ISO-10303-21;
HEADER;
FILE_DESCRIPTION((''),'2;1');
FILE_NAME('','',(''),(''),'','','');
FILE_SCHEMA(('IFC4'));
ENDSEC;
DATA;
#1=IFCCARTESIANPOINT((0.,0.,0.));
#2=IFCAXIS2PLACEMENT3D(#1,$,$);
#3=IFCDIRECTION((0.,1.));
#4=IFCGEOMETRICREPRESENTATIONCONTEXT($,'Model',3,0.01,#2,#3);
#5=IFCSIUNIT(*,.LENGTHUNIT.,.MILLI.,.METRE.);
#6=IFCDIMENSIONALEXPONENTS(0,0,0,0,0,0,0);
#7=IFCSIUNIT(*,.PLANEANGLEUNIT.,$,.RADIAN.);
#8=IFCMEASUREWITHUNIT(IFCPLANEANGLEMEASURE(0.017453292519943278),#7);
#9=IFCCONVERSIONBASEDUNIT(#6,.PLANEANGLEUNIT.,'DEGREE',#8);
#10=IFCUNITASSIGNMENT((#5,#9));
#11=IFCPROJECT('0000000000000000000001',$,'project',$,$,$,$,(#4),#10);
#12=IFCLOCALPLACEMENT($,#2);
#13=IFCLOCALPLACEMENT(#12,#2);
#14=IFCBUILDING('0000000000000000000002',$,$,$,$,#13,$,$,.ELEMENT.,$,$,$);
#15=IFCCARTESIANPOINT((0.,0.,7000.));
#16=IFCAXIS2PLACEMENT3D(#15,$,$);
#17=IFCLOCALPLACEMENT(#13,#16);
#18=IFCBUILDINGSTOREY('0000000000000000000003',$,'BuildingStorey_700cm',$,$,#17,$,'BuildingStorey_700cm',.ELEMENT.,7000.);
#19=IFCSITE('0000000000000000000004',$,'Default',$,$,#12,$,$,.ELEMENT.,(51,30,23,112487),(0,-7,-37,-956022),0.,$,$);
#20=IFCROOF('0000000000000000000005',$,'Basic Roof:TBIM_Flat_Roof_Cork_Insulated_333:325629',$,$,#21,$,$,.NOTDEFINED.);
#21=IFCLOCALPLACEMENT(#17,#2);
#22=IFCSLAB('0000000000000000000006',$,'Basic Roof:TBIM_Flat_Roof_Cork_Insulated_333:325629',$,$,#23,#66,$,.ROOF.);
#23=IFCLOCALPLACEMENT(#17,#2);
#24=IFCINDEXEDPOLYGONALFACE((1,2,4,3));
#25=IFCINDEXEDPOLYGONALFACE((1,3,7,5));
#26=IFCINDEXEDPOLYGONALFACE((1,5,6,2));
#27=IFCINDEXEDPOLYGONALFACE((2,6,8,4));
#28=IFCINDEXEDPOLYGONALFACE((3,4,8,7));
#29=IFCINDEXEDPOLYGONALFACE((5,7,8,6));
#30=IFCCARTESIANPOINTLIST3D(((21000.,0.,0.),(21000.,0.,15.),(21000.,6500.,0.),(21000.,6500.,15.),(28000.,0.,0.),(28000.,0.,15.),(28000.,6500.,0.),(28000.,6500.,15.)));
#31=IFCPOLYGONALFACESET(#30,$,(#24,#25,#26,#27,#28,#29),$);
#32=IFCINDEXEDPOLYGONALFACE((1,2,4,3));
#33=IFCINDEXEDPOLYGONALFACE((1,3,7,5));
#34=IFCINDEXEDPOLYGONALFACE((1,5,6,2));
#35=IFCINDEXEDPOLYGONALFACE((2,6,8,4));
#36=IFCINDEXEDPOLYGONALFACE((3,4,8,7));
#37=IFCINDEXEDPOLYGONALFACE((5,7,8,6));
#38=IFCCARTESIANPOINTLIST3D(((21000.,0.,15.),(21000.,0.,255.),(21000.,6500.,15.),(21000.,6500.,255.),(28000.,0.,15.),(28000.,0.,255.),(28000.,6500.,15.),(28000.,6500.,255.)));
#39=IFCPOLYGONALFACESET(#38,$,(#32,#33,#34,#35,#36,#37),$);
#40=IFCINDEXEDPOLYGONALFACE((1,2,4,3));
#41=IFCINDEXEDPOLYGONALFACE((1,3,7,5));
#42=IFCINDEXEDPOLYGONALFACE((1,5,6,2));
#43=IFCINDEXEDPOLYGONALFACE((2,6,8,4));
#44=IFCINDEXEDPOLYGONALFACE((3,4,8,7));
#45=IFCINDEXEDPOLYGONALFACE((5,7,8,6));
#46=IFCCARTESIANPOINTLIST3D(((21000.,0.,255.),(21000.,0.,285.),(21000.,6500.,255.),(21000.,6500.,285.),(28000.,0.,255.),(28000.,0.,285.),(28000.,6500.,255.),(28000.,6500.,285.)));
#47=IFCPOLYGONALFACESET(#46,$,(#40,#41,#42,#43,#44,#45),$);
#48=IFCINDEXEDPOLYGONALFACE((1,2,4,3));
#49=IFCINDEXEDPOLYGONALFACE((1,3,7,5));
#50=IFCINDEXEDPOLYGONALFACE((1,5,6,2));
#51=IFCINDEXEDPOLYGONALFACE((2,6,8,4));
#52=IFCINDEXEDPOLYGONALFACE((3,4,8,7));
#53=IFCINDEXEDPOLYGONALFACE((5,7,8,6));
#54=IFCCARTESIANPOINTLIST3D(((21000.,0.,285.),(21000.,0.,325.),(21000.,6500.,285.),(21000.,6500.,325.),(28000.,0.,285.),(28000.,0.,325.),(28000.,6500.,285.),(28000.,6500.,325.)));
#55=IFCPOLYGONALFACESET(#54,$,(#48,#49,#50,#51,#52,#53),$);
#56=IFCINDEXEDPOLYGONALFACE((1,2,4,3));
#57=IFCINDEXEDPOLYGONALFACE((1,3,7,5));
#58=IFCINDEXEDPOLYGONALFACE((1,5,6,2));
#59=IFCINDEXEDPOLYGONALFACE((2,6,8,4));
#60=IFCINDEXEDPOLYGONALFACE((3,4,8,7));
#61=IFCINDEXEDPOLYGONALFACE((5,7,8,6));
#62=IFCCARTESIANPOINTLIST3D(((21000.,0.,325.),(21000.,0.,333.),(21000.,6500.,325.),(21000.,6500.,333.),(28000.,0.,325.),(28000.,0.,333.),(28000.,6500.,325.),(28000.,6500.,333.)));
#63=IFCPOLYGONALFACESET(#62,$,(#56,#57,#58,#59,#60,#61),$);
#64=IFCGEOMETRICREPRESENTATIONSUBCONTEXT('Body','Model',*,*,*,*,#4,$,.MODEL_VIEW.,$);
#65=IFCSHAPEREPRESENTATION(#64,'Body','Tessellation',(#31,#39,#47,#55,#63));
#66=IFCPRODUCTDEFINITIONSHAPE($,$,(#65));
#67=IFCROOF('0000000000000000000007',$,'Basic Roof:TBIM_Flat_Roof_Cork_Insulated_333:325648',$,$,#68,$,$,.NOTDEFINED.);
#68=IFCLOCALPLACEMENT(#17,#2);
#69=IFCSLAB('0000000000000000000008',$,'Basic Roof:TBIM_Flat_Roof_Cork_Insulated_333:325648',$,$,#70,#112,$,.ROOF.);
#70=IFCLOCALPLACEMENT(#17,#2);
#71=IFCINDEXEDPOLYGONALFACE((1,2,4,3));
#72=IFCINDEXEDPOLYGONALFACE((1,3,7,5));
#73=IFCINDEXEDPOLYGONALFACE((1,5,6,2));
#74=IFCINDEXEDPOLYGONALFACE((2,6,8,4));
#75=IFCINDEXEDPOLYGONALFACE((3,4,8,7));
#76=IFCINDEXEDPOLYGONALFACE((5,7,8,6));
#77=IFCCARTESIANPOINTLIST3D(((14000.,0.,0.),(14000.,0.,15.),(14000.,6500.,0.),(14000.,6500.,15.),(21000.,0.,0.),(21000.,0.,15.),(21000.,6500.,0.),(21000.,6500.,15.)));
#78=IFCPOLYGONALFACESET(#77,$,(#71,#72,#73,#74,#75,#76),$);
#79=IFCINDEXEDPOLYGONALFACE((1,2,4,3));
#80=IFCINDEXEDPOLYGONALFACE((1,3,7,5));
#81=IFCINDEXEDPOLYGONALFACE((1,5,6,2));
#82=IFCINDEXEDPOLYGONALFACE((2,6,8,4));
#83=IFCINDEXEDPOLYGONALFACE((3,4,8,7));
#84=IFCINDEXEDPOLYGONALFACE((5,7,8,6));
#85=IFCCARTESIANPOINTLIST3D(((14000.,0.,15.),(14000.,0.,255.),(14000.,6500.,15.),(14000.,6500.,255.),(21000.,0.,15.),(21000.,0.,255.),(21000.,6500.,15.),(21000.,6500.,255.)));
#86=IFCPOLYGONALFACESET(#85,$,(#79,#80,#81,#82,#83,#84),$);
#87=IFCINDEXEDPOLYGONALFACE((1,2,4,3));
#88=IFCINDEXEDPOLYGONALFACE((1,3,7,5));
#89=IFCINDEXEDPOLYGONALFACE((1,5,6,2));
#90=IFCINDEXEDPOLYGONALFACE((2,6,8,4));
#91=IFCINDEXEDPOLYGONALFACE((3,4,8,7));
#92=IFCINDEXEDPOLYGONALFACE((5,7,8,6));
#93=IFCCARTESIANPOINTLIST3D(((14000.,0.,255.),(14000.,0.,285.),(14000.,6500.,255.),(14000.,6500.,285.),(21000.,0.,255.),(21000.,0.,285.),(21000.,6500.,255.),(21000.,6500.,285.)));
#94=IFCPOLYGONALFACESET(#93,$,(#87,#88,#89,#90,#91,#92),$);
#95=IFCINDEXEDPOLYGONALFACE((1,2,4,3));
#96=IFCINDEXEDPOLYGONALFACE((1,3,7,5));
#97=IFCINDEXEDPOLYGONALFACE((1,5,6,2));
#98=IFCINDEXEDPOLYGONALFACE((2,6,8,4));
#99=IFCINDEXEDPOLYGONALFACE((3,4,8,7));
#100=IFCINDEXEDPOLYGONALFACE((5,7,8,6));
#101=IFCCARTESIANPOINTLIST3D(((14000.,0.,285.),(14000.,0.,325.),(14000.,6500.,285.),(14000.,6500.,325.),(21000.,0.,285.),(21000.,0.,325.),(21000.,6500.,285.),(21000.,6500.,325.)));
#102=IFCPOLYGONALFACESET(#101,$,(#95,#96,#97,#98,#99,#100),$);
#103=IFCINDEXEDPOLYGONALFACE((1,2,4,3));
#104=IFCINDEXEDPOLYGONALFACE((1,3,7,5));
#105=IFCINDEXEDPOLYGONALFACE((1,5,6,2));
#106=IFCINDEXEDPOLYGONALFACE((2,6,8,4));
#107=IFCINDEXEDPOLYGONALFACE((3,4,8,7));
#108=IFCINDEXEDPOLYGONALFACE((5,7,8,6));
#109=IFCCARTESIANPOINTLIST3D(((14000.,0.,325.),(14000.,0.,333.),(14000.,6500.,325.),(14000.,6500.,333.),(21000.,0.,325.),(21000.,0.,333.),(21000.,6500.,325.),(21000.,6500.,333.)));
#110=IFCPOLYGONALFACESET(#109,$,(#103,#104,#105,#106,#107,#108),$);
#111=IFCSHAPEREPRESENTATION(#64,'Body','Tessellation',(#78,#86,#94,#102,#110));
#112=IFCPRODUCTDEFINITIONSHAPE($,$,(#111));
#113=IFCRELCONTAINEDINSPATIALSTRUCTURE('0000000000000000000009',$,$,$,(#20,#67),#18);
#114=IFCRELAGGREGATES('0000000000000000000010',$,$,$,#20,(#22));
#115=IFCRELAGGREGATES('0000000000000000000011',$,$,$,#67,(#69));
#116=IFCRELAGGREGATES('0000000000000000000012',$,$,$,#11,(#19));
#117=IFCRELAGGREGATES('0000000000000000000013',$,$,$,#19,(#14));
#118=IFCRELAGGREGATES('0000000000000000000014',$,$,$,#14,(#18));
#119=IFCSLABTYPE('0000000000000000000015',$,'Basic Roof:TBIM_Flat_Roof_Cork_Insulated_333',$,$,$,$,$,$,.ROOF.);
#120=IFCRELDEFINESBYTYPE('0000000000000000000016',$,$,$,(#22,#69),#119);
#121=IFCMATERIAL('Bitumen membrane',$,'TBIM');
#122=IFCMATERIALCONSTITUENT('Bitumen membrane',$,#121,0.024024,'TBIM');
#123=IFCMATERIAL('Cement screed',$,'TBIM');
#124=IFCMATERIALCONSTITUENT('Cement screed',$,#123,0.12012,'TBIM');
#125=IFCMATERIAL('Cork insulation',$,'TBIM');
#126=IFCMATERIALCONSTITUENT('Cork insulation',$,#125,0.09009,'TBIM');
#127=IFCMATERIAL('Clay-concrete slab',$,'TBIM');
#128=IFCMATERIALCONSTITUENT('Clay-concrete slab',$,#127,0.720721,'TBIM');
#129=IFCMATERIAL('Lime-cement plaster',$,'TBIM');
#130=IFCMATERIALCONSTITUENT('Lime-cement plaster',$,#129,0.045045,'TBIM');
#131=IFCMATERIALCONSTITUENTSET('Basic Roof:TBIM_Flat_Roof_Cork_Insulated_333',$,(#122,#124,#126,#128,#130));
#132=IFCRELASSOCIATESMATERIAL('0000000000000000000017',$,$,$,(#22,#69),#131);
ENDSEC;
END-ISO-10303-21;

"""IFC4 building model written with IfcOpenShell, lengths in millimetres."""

from ifc_helpers import new_model, entity, si_unit, converted_unit, direction, frame, origin, place, context, subcontext, project, spatial, indexed_curve, outline, extrude, material, constituent, constituent_set, type_object, element, aggregate, save


model = new_model("IFC4")

# Units and contexts
model_context = context("Model", 3, precision=0.01, world=origin(), true_north=direction((0.0, 1.0)))
body_context = subcontext(model_context, "Body", "Model", "MODEL_VIEW")
ifc_project = project(units=[si_unit("LENGTHUNIT", "METRE", prefix="MILLI"), converted_unit("PLANEANGLEUNIT", "DEGREE", entity("IfcPlaneAngleMeasure", 0.017453292519943278), si_unit("PLANEANGLEUNIT", "RADIAN"), dimensions=[0, 0, 0, 0, 0, 0, 0])], contexts=[model_context])

# Site, building, storey
site_placement = place(None, origin())
site = spatial("IfcSite", under=ifc_project, at=site_placement, Name="Default", CompositionType="ELEMENT", RefLatitude=(51, 30, 23, 112487), RefLongitude=(0, -7, -37, -956022), RefElevation=0.0)
building_placement = place(site_placement, origin())
building = spatial("IfcBuilding", under=site, at=building_placement, CompositionType="ELEMENT")
storey_placement = place(building_placement, frame((0.0, 0.0, 7000.0)))
storey = spatial("IfcBuildingStorey", under=building, at=storey_placement, Name="BuildingStorey_700cm", LongName="BuildingStorey_700cm", CompositionType="ELEMENT", Elevation=7000.0)

# Roofs, slabs
ifc_material_1 = material(Name="Bitumen membrane", Category="TBIM")
ifc_constituent_1 = constituent(ifc_material_1, Name="Bitumen membrane", Category="TBIM", fraction=0.024024)
ifc_material_2 = material(Name="Cement screed", Category="TBIM")
ifc_constituent_2 = constituent(ifc_material_2, Name="Cement screed", Category="TBIM", fraction=0.12012)
ifc_material_3 = material(Name="Cork insulation", Category="TBIM")
ifc_constituent_3 = constituent(ifc_material_3, Name="Cork insulation", Category="TBIM", fraction=0.09009)
ifc_material_4 = material(Name="Clay-concrete slab", Category="TBIM")
ifc_constituent_4 = constituent(ifc_material_4, Name="Clay-concrete slab", Category="TBIM", fraction=0.720721)
ifc_material_5 = material(Name="Lime-cement plaster", Category="TBIM")
ifc_constituent_5 = constituent(ifc_material_5, Name="Lime-cement plaster", Category="TBIM", fraction=0.045045)
ifc_constituent_set = constituent_set(constituents=[ifc_constituent_1, ifc_constituent_2, ifc_constituent_3, ifc_constituent_4, ifc_constituent_5], Name="Basic Roof:TBIM_Flat_Roof_Cork_Insulated_333")
slab_type = type_object("IfcSlabType", Name="Basic Roof:TBIM_Flat_Roof_Cork_Insulated_333", PredefinedType="ROOF")
roof_1_placement = place(storey_placement, frame((21000.0, 0.0, 0.0)))
roof_1 = element("IfcRoof", 1, at=roof_1_placement, inside=storey, Name="Basic Roof:TBIM_Flat_Roof_Cork_Insulated_333:325629", PredefinedType="NOTDEFINED")
slab_1_placement = place(roof_1_placement, origin())
slab_1 = element("IfcSlab", 2, at=slab_1_placement, type_object=slab_type, material=ifc_constituent_set, Name="Basic Roof:TBIM_Flat_Roof_Cork_Insulated_333:325629", PredefinedType="ROOF", context=body_context, shape_type="SweptSolid", body=[
    extrude(outline(indexed_curve([(-3500.0, 3250.0), (-3500.0, -3250.0), (3500.0, -3250.0), (3500.0, 3250.0), (-3500.0, 3250.0)], self_intersect=False)), frame((3500.0, 3250.0, 0.0)), (0.0, 0.0, 1.0), 15.0),
    extrude(outline(indexed_curve([(-3500.0, 3250.0), (-3500.0, -3250.0), (3500.0, -3250.0), (3500.0, 3250.0), (-3500.0, 3250.0)], self_intersect=False)), frame((3500.0, 3250.0, 15.0)), (0.0, 0.0, 1.0), 240.0),
    extrude(outline(indexed_curve([(-3500.0, 3250.0), (-3500.0, -3250.0), (3500.0, -3250.0), (3500.0, 3250.0), (-3500.0, 3250.0)], self_intersect=False)), frame((3500.0, 3250.0, 255.0)), (0.0, 0.0, 1.0), 30.0),
    extrude(outline(indexed_curve([(-3500.0, 3250.0), (-3500.0, -3250.0), (3500.0, -3250.0), (3500.0, 3250.0), (-3500.0, 3250.0)], self_intersect=False)), frame((3500.0, 3250.0, 285.0)), (0.0, 0.0, 1.0), 40.0),
    extrude(outline(indexed_curve([(-3500.0, 3250.0), (-3500.0, -3250.0), (3500.0, -3250.0), (3500.0, 3250.0), (-3500.0, 3250.0)], self_intersect=False)), frame((3500.0, 3250.0, 325.0)), (0.0, 0.0, 1.0), 8.0),
])
aggregate(roof_1, [slab_1])
roof_2_placement = place(storey_placement, frame((14000.0, 0.0, 0.0)))
roof_2 = element("IfcRoof", 3, at=roof_2_placement, inside=storey, Name="Basic Roof:TBIM_Flat_Roof_Cork_Insulated_333:325648", PredefinedType="NOTDEFINED")
slab_2_placement = place(roof_2_placement, origin())
slab_2 = element("IfcSlab", 4, at=slab_2_placement, type_object=slab_type, material=ifc_constituent_set, Name="Basic Roof:TBIM_Flat_Roof_Cork_Insulated_333:325648", PredefinedType="ROOF", context=body_context, shape_type="SweptSolid", body=[
    extrude(outline(indexed_curve([(-3500.0, 3250.0), (-3500.0, -3250.0), (3500.0, -3250.0), (3500.0, 3250.0), (-3500.0, 3250.0)], self_intersect=False)), frame((3500.0, 3250.0, 0.0)), (0.0, 0.0, 1.0), 15.0),
    extrude(outline(indexed_curve([(-3500.0, 3250.0), (-3500.0, -3250.0), (3500.0, -3250.0), (3500.0, 3250.0), (-3500.0, 3250.0)], self_intersect=False)), frame((3500.0, 3250.0, 15.0)), (0.0, 0.0, 1.0), 240.0),
    extrude(outline(indexed_curve([(-3500.0, 3250.0), (-3500.0, -3250.0), (3500.0, -3250.0), (3500.0, 3250.0), (-3500.0, 3250.0)], self_intersect=False)), frame((3500.0, 3250.0, 255.0)), (0.0, 0.0, 1.0), 30.0),
    extrude(outline(indexed_curve([(-3500.0, 3250.0), (-3500.0, -3250.0), (3500.0, -3250.0), (3500.0, 3250.0), (-3500.0, 3250.0)], self_intersect=False)), frame((3500.0, 3250.0, 285.0)), (0.0, 0.0, 1.0), 40.0),
    extrude(outline(indexed_curve([(-3500.0, 3250.0), (-3500.0, -3250.0), (3500.0, -3250.0), (3500.0, 3250.0), (-3500.0, 3250.0)], self_intersect=False)), frame((3500.0, 3250.0, 325.0)), (0.0, 0.0, 1.0), 8.0),
])
aggregate(roof_2, [slab_2])

save(model, "model.ifc")
